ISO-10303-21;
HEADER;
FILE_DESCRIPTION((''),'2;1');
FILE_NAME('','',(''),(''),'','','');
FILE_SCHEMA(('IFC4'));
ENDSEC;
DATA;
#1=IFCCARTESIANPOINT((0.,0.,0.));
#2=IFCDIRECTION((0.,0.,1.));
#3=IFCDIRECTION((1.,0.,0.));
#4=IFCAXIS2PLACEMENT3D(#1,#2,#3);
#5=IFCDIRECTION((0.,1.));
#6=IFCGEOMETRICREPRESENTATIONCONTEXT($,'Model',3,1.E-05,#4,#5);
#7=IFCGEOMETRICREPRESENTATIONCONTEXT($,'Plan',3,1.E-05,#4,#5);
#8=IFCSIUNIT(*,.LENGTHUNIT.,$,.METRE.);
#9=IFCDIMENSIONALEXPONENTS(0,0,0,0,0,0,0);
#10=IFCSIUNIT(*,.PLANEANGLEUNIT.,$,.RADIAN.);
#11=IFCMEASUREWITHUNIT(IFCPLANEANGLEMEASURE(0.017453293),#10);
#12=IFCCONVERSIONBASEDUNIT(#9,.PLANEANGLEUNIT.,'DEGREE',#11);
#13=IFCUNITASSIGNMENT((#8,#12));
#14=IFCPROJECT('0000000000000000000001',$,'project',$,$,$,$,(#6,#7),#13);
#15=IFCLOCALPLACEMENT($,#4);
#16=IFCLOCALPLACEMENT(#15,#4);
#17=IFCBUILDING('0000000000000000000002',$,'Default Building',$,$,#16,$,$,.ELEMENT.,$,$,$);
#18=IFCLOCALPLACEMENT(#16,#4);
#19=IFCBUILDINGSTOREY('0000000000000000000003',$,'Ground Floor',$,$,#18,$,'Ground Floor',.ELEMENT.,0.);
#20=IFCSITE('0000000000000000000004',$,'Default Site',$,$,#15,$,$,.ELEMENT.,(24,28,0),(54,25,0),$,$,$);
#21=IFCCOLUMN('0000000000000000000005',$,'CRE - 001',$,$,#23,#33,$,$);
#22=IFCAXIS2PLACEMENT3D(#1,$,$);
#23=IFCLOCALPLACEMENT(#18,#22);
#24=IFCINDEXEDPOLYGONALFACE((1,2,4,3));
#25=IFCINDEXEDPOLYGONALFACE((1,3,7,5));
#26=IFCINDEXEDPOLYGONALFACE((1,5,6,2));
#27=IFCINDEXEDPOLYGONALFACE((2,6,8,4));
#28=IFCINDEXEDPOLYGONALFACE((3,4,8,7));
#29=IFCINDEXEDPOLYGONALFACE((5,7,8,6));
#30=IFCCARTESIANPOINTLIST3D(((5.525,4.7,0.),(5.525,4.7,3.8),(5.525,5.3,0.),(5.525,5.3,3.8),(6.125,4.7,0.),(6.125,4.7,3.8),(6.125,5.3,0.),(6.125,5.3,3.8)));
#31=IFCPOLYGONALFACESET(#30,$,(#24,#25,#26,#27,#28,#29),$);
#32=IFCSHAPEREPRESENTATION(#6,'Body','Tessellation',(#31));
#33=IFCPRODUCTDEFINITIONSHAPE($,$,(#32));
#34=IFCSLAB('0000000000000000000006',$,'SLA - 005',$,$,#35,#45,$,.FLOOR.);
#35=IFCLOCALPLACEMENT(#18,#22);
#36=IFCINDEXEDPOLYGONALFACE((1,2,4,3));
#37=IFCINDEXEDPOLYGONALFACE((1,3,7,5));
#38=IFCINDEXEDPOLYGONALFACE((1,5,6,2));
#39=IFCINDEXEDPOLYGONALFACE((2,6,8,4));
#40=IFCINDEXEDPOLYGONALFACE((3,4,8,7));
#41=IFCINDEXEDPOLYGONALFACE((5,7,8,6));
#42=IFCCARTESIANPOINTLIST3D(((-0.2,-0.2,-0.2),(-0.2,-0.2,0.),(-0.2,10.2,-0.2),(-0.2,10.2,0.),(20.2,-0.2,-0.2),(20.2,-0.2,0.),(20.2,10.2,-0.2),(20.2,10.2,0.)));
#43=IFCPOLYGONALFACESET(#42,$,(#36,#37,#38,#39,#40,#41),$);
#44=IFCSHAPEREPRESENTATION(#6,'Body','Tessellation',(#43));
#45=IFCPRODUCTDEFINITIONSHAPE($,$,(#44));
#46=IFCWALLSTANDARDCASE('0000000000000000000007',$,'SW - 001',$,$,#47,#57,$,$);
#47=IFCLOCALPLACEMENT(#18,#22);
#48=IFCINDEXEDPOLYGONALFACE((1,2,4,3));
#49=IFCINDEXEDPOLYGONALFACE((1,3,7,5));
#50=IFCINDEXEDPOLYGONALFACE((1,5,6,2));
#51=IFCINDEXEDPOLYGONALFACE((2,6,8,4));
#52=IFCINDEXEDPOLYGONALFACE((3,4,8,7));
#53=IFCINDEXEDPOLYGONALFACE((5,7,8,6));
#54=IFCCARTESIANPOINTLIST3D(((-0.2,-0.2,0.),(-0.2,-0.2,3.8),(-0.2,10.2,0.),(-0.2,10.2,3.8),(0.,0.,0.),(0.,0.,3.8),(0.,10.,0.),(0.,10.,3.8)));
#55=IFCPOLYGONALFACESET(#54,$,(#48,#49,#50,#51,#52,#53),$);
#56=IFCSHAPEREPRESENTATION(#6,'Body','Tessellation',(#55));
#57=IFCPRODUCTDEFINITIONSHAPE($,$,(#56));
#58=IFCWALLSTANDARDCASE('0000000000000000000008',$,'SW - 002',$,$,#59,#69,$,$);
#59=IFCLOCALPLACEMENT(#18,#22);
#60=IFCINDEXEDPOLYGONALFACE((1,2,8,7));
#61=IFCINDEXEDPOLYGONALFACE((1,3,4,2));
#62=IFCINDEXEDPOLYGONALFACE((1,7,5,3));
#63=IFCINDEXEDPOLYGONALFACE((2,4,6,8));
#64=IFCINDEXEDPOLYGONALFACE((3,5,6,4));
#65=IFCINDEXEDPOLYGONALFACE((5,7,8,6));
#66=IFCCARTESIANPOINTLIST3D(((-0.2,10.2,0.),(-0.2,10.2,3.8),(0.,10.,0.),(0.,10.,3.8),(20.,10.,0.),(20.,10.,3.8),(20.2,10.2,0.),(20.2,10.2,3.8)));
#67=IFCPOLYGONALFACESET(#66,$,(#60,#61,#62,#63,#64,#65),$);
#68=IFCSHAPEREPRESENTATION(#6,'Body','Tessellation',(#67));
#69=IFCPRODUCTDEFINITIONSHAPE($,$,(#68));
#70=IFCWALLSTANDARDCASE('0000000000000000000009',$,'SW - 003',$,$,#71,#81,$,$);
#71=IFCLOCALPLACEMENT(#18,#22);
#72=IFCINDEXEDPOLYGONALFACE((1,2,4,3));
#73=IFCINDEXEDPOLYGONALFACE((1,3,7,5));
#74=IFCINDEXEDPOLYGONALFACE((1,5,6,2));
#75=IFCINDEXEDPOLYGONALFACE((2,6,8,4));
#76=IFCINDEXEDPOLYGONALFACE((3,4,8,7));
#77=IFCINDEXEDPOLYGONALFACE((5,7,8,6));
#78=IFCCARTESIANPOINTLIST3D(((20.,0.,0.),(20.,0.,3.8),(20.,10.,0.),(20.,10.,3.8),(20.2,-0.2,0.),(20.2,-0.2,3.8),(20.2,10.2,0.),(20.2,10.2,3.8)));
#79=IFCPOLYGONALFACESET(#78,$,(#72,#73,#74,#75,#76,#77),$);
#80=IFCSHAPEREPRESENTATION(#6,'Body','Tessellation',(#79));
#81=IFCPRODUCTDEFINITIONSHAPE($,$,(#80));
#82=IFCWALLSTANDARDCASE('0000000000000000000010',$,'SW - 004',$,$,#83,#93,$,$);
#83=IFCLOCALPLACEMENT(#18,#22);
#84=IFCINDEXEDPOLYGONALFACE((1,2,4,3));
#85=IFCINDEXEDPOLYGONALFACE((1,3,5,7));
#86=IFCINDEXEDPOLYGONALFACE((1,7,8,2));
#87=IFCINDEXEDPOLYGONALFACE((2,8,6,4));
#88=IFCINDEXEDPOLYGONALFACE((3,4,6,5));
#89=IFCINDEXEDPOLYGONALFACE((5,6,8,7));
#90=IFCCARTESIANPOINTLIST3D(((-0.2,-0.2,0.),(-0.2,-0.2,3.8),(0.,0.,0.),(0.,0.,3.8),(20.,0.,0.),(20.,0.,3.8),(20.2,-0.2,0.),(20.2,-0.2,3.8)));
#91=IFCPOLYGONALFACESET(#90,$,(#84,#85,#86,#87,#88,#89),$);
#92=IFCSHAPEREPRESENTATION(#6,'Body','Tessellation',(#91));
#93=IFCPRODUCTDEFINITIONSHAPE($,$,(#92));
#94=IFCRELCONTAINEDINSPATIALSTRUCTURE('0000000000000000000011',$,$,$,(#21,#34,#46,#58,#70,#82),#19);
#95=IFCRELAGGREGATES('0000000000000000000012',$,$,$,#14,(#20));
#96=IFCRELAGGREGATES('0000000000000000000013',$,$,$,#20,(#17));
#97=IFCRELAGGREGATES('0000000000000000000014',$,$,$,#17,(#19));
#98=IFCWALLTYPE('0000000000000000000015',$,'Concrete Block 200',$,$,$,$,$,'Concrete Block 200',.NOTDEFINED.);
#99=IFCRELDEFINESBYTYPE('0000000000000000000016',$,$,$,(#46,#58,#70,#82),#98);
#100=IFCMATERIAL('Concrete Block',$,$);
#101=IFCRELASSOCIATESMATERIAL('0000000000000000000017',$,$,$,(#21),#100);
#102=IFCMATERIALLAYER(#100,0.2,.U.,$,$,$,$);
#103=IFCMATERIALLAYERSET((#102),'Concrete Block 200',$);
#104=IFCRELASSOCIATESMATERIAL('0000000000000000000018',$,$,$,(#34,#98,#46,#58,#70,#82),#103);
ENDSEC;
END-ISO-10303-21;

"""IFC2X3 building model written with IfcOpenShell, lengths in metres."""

from ifc_helpers import new_model, entity, si_unit, converted_unit, direction, frame, origin_with_axes, origin_2d_with_axis, place, context, project, spatial, polyline, rectangle, outline, extrude, material, layer, layer_set, layer_usage, type_object, element, save


model = new_model("IFC2X3")

# Units and contexts
model_context = context("Model", 3, precision=1e-05, world=origin_with_axes(), true_north=direction((0.0, 1.0)))
plan_context = context("Plan", 3, precision=1e-05, world=origin_with_axes(), true_north=direction((0.0, 1.0)))
ifc_project = project(units=[si_unit("LENGTHUNIT", "METRE"), converted_unit("PLANEANGLEUNIT", "DEGREE", entity("IfcPlaneAngleMeasure", 0.017453293), si_unit("PLANEANGLEUNIT", "RADIAN"), dimensions=[0, 0, 0, 0, 0, 0, 0])], contexts=[model_context, plan_context])

# Site, building, storey
site_placement = place(None, origin_with_axes())
site = spatial("IfcSite", under=ifc_project, at=site_placement, Name="Default Site", CompositionType="ELEMENT", RefLatitude=(24, 28, 0), RefLongitude=(54, 25, 0))
building_placement = place(site_placement, origin_with_axes())
building = spatial("IfcBuilding", under=site, at=building_placement, Name="Default Building", CompositionType="ELEMENT")
storey_placement = place(building_placement, origin_with_axes())
storey = spatial("IfcBuildingStorey", under=building, at=storey_placement, Name="Ground Floor", LongName="Ground Floor", CompositionType="ELEMENT", Elevation=0.0)

# Column
ifc_material = material(Name="Concrete Block")
column_placement = place(storey_placement, frame((5.825, 5.0, 0.0), z_axis=(0.0, 0.0, 1.0), x_axis=(1.0, 0.0, 0.0)))
element("IfcColumn", 1, at=column_placement, inside=storey, material=ifc_material, Name="CRE - 001", context=model_context, shape_type="SweptSolid", body=[
    extrude(rectangle(XDim=0.6, YDim=0.6, at=origin_2d_with_axis()), origin_with_axes(), (0.0, 0.0, 1.0), 3.8),
])

# Slab
ifc_layer = layer(ifc_material, 0.2, ventilated="UNKNOWN")
ifc_layer_set = layer_set([ifc_layer], Name="Concrete Block 200")
ifc_layer_usage_1 = layer_usage(ifc_layer_set, "AXIS3", "NEGATIVE", 0.2)
slab_placement = place(storey_placement, frame((-0.2, 10.2, -0.2), z_axis=(0.0, 0.0, 1.0), x_axis=(1.0, 0.0, 0.0)))
element("IfcSlab", 2, at=slab_placement, inside=storey, material=ifc_layer_usage_1, Name="SLA - 005", PredefinedType="FLOOR", context=model_context, shape_type="SweptSolid", body=[
    extrude(outline(polyline([(0.0, 0.0), (20.4, 0.0), (20.4, -10.4), (0.0, -10.4), (0.0, 0.0)])), origin_with_axes(), (0.0, 0.0, 1.0), 0.2),
])

# Walls
ifc_layer_usage_2 = layer_usage(ifc_layer_set, "AXIS2", "POSITIVE", 0.0)
wall_type = type_object("IfcWallType", Name="Concrete Block 200", ElementType="Concrete Block 200", PredefinedType="NOTDEFINED", material=ifc_layer_set)
wall_1_placement = place(storey_placement, frame((0.0, 0.0, 0.0), z_axis=(0.0, 0.0, 1.0), x_axis=(0.0, 1.0, 0.0)))
element("IfcWallStandardCase", 3, at=wall_1_placement, inside=storey, type_object=wall_type, material=ifc_layer_usage_2, Name="SW - 001", context=model_context, shape_type="SweptSolid", body=[
    extrude(outline(polyline([(0.0, 0.0), (10.0, 0.0), (10.2, 0.2), (-0.2, 0.2), (0.0, 0.0)])), origin_with_axes(), (0.0, 0.0, 1.0), 3.8),
])
ifc_layer_usage_3 = layer_usage(ifc_layer_set, "AXIS2", "POSITIVE", 0.0)
wall_2_placement = place(storey_placement, frame((0.0, 10.0, 0.0), z_axis=(0.0, 0.0, 1.0), x_axis=(1.0, 0.0, 0.0)))
element("IfcWallStandardCase", 4, at=wall_2_placement, inside=storey, type_object=wall_type, material=ifc_layer_usage_3, Name="SW - 002", context=model_context, shape_type="SweptSolid", body=[
    extrude(outline(polyline([(0.0, 0.0), (20.0, 0.0), (20.2, 0.2), (-0.2, 0.2), (0.0, 0.0)])), origin_with_axes(), (0.0, 0.0, 1.0), 3.8),
])
ifc_layer_usage_4 = layer_usage(ifc_layer_set, "AXIS2", "POSITIVE", 0.0)
wall_3_placement = place(storey_placement, frame((20.0, 10.0, 0.0), z_axis=(0.0, 0.0, 1.0), x_axis=(0.0, -1.0, 0.0)))
element("IfcWallStandardCase", 5, at=wall_3_placement, inside=storey, type_object=wall_type, material=ifc_layer_usage_4, Name="SW - 003", context=model_context, shape_type="SweptSolid", body=[
    extrude(outline(polyline([(0.0, 0.0), (10.0, 0.0), (10.2, 0.2), (-0.2, 0.2), (0.0, 0.0)])), origin_with_axes(), (0.0, 0.0, 1.0), 3.8),
])
ifc_layer_usage_5 = layer_usage(ifc_layer_set, "AXIS2", "POSITIVE", 0.0)
wall_4_placement = place(storey_placement, frame((20.0, 0.0, 0.0), z_axis=(0.0, 0.0, 1.0), x_axis=(-1.0, 0.0, 0.0)))
element("IfcWallStandardCase", 6, at=wall_4_placement, inside=storey, type_object=wall_type, material=ifc_layer_usage_5, Name="SW - 004", context=model_context, shape_type="SweptSolid", body=[
    extrude(outline(polyline([(0.0, 0.0), (20.0, 0.0), (20.2, 0.2), (-0.2, 0.2), (0.0, 0.0)])), origin_with_axes(), (0.0, 0.0, 1.0), 3.8),
])

save(model, "model.ifc")
